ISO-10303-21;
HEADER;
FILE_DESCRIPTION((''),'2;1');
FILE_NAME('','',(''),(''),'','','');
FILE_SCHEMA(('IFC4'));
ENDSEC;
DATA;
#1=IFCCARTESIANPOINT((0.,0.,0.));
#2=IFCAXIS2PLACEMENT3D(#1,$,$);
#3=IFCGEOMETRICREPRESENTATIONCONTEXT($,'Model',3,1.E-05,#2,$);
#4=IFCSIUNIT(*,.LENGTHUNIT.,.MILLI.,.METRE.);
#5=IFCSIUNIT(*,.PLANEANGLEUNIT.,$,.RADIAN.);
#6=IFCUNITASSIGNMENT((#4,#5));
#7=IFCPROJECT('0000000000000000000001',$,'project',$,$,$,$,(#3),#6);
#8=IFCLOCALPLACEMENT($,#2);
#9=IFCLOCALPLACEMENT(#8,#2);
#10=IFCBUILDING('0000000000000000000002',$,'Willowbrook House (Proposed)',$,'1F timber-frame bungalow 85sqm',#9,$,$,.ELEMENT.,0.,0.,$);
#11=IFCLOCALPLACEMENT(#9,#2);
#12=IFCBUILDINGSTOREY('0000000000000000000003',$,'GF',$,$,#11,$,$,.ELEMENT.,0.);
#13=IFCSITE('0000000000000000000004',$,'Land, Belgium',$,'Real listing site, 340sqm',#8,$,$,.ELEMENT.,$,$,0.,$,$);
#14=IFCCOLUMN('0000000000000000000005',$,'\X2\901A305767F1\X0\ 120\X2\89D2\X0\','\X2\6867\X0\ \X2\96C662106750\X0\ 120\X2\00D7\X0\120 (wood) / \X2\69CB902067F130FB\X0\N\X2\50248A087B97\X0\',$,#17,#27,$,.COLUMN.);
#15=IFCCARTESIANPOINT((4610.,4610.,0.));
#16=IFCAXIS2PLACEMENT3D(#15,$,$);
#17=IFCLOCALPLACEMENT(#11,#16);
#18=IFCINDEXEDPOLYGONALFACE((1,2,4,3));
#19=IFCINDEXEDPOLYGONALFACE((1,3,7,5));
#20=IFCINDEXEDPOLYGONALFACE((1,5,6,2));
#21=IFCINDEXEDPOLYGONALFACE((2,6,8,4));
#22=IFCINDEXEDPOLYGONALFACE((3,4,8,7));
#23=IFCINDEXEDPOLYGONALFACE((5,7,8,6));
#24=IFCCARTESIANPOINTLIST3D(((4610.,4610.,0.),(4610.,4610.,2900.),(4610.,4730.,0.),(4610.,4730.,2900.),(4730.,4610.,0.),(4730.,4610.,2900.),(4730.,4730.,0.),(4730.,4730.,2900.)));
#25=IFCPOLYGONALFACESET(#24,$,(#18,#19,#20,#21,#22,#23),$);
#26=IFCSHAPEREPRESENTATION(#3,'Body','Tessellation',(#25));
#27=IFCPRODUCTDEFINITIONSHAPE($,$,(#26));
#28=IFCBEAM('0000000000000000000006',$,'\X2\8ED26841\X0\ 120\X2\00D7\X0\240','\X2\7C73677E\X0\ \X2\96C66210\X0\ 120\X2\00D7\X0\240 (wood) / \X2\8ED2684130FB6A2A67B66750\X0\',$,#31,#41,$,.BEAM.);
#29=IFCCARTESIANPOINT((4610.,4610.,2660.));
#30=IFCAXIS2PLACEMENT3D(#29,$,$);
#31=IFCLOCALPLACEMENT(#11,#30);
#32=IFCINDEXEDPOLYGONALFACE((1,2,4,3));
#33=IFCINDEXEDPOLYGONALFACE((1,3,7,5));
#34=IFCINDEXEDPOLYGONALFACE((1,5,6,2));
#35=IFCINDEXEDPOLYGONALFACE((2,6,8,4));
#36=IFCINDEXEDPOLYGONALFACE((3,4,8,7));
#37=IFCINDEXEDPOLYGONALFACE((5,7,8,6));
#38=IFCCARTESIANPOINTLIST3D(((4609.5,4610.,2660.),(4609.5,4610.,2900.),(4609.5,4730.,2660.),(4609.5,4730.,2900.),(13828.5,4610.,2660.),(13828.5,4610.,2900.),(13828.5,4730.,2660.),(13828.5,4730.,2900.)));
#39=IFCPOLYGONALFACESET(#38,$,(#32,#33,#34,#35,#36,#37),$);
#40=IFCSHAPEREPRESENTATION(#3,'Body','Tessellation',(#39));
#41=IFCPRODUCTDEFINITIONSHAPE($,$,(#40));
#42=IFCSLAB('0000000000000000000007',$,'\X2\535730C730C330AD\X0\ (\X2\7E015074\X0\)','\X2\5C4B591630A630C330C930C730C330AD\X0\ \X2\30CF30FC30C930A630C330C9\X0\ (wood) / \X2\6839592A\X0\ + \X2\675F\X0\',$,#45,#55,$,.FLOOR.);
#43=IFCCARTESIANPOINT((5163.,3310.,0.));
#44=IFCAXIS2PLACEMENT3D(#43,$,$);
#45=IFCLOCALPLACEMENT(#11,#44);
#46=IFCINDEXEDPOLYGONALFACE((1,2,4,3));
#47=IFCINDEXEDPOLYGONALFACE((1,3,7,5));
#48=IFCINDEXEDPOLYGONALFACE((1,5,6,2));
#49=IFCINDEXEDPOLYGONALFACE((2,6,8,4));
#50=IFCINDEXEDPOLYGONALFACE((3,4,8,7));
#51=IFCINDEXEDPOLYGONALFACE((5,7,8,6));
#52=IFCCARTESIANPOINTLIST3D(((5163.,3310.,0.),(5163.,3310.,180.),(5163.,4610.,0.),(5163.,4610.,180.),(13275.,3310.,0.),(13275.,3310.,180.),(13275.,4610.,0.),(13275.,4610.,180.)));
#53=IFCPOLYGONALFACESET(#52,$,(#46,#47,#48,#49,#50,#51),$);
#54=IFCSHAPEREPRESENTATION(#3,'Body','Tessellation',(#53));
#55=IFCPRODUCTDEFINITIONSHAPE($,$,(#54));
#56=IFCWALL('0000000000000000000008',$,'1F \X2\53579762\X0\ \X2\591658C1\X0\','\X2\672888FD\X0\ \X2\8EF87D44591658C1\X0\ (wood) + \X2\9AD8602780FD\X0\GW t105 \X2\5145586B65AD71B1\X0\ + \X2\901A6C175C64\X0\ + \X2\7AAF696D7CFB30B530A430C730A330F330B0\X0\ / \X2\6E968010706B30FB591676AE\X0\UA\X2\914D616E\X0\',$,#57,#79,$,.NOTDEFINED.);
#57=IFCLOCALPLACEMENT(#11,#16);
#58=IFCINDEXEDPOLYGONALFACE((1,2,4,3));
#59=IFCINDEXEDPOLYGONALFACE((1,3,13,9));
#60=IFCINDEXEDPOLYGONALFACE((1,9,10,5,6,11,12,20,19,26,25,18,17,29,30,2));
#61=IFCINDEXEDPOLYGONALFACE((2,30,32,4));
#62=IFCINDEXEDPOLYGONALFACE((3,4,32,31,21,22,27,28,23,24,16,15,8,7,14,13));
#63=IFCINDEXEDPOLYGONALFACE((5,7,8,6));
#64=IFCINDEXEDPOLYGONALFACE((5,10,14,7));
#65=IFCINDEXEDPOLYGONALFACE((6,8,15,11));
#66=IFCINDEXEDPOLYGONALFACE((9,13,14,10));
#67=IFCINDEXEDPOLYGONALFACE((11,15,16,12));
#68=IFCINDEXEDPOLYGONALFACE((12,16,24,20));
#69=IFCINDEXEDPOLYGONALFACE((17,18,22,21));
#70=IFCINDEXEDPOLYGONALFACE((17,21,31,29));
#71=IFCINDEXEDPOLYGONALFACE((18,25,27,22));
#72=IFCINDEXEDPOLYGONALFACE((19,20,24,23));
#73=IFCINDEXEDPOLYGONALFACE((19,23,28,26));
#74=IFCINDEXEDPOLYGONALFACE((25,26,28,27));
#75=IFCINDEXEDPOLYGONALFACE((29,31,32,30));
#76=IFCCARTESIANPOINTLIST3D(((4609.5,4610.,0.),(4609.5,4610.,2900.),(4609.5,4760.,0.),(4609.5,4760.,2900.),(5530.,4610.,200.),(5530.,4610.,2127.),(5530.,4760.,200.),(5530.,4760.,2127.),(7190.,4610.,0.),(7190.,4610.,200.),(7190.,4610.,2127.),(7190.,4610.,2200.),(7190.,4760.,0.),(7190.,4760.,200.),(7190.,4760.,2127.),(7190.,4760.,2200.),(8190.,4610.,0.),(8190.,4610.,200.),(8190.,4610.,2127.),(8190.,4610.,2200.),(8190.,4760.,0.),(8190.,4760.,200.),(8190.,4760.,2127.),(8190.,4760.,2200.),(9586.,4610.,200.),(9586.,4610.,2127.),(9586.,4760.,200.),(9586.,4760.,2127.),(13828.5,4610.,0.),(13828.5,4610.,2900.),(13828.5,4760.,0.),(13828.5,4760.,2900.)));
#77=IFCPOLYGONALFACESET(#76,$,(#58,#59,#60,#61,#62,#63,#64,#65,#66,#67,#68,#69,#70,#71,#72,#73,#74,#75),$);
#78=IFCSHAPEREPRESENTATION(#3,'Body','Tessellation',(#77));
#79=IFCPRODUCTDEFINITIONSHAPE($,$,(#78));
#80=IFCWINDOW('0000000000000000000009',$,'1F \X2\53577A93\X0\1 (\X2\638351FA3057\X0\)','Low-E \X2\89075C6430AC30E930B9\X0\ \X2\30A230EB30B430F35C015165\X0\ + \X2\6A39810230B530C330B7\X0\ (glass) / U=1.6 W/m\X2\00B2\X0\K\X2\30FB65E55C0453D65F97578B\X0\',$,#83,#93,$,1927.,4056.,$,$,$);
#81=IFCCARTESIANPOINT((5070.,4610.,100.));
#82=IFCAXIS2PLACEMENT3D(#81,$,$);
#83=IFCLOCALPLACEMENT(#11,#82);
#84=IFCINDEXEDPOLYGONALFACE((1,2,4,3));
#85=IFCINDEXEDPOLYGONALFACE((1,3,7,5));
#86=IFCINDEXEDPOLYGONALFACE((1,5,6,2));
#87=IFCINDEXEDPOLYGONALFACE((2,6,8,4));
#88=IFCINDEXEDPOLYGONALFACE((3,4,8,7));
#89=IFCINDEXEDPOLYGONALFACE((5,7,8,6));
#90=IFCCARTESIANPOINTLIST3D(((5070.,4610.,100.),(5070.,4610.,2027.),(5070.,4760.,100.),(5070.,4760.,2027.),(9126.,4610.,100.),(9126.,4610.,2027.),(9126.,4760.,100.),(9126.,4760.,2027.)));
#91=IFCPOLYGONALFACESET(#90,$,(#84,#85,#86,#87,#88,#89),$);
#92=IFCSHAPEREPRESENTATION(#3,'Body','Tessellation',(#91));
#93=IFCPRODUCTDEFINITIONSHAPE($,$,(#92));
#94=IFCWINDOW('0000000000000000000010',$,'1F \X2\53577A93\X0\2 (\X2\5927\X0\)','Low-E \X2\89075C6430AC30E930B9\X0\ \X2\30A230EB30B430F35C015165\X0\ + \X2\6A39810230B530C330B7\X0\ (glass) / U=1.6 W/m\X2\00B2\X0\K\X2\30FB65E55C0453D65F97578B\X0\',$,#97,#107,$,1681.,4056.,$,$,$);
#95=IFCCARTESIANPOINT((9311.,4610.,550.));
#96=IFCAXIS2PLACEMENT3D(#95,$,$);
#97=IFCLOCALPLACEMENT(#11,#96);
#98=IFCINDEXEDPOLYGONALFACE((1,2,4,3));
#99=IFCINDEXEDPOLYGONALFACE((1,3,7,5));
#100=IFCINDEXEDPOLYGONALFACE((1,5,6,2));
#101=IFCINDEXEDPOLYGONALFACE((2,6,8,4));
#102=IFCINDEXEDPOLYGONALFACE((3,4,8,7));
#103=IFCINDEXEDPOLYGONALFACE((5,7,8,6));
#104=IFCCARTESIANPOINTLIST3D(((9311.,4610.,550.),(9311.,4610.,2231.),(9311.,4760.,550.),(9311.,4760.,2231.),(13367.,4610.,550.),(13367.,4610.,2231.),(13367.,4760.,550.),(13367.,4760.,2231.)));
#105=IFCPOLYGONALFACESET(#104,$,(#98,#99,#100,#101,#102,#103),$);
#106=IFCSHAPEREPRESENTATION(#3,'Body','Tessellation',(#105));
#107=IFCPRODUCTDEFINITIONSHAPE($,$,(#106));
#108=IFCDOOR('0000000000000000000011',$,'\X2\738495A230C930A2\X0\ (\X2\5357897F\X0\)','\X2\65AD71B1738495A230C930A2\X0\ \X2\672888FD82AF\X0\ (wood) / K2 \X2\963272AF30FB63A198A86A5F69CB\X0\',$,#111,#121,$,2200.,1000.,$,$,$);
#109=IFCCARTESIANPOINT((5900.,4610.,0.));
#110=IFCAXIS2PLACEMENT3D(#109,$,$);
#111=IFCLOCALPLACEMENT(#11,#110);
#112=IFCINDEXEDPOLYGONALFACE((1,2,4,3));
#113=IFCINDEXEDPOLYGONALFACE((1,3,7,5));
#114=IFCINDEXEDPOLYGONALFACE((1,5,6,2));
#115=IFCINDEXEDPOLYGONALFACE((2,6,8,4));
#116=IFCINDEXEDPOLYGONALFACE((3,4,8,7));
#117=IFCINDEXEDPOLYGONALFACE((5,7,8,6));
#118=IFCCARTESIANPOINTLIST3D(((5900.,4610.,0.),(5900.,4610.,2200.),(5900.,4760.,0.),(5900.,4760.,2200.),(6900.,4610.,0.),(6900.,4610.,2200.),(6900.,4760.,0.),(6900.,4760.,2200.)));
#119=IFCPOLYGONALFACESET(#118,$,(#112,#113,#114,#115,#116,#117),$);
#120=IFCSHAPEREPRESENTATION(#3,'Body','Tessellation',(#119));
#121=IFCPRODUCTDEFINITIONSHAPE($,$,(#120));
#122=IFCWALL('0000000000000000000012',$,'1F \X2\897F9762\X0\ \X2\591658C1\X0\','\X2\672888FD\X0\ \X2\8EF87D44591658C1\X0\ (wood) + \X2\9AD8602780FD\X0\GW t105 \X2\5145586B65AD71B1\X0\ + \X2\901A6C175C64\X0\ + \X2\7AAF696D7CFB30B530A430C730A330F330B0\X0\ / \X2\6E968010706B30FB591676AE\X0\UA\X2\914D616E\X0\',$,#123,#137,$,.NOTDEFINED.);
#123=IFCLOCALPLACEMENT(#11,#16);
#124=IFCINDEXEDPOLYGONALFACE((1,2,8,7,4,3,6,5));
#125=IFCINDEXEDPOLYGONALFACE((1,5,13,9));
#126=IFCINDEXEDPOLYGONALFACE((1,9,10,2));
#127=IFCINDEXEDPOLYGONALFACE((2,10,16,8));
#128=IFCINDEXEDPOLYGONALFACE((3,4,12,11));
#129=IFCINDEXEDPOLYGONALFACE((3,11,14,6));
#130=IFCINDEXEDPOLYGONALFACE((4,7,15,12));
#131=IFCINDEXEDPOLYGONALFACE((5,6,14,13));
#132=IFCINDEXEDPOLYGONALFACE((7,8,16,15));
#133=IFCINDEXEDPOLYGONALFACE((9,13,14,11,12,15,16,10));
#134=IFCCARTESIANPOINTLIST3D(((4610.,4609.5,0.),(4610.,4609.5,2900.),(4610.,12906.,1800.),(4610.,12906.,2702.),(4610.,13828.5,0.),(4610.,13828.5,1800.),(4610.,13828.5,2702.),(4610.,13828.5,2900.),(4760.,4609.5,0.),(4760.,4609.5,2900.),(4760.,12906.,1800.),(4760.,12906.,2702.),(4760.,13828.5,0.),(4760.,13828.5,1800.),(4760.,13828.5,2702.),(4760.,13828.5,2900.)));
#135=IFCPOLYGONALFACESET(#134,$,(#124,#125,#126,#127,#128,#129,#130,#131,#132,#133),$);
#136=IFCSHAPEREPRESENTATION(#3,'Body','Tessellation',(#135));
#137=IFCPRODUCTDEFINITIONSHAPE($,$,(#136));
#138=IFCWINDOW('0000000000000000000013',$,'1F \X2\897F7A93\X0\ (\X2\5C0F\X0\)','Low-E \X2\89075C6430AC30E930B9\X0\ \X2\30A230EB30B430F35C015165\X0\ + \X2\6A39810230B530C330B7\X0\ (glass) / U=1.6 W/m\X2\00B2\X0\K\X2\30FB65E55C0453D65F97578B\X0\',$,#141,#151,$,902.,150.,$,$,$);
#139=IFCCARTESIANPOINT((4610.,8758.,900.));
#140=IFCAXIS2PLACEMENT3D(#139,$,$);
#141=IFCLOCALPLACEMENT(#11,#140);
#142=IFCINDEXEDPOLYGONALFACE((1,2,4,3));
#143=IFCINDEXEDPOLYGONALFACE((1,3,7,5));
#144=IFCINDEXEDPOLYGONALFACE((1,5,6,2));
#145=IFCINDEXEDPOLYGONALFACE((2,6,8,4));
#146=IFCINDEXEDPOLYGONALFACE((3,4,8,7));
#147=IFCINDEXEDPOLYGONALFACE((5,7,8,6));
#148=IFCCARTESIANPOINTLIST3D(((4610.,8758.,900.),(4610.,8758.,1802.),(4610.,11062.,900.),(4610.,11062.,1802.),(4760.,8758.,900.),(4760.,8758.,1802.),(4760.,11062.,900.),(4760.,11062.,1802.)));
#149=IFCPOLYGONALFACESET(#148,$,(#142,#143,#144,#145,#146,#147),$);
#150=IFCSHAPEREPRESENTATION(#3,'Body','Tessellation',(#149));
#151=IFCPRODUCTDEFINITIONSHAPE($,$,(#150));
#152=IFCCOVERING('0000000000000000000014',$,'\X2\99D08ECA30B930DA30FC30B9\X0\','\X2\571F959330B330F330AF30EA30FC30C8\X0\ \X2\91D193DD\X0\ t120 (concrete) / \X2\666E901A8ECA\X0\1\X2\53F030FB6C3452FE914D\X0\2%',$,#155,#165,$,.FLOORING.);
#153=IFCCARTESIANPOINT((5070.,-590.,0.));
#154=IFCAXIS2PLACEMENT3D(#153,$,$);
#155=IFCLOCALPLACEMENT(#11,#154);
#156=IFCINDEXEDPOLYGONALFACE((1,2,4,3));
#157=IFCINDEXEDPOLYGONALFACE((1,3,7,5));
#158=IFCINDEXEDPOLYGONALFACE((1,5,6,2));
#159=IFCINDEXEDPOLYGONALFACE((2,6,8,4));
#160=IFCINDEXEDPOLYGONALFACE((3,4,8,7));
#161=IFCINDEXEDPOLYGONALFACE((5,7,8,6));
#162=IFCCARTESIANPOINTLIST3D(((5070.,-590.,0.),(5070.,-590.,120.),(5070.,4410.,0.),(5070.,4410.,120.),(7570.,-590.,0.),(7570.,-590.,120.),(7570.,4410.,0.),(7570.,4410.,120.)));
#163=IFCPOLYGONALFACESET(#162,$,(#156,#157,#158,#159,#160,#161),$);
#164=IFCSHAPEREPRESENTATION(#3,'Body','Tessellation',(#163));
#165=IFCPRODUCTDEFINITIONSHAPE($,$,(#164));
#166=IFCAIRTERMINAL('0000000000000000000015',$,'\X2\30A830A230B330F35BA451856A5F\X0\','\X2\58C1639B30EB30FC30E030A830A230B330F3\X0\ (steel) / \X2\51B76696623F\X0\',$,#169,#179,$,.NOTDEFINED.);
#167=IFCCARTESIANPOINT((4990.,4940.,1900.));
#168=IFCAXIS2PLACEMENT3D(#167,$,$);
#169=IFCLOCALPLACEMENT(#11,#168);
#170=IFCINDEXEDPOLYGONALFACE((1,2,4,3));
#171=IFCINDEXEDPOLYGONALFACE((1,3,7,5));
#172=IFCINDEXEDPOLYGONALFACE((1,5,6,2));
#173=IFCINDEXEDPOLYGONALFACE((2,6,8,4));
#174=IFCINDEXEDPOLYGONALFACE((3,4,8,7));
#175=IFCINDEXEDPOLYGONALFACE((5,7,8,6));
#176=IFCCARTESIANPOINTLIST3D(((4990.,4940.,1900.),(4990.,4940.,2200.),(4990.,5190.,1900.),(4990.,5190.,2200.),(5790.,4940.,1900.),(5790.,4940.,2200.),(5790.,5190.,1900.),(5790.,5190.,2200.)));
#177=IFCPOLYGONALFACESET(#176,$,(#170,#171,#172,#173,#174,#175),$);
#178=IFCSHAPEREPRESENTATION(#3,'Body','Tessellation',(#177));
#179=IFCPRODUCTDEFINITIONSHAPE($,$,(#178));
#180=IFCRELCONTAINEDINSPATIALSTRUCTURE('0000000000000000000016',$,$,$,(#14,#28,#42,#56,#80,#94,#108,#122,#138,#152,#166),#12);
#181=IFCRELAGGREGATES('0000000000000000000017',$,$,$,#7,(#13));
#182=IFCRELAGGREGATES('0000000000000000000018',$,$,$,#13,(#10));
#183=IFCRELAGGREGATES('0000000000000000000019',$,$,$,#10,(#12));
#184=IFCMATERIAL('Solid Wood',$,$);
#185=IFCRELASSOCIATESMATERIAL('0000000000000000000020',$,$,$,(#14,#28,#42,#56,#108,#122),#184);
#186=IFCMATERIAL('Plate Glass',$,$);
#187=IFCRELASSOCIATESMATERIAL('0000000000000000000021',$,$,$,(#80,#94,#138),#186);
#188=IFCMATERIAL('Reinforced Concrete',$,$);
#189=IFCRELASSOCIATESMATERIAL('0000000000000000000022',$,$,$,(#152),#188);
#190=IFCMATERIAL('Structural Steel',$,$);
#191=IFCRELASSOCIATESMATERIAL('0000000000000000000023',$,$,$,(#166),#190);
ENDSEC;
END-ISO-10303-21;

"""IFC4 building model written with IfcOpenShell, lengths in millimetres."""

from ifc_helpers import new_model, si_unit, frame, frame_2d, origin, place, context, project, spatial, rectangle, extrude, material, element, fill, save


model = new_model("IFC4")

# Units and contexts
model_context = context("Model", 3, precision=1e-05, world=origin())
ifc_project = project(units=[si_unit("LENGTHUNIT", "METRE", prefix="MILLI"), si_unit("PLANEANGLEUNIT", "RADIAN")], contexts=[model_context])

# Site, building, storey
site_placement = place(None, origin())
site = spatial("IfcSite", under=ifc_project, at=site_placement, Name="Land, Belgium", ObjectType="Real listing site, 340sqm", CompositionType="ELEMENT", RefElevation=0.0)
building_placement = place(site_placement, origin())
building = spatial("IfcBuilding", under=site, at=building_placement, Name="Willowbrook House (Proposed)", ObjectType="1F timber-frame bungalow 85sqm", CompositionType="ELEMENT", ElevationOfRefHeight=0.0, ElevationOfTerrain=0.0)
storey_placement = place(building_placement, origin())
storey = spatial("IfcBuildingStorey", under=building, at=storey_placement, Name="GF", CompositionType="ELEMENT", Elevation=0.0)

# Column
ifc_material_1 = material(Name="Solid Wood")
column_1_placement = place(storey_placement, frame((4610.0, 4610.0, 0.0)))
element("IfcColumn", 1, at=column_1_placement, inside=storey, material=ifc_material_1, Name="通し柱 120角", Description="桧 集成材 120×120 (wood) / 構造柱・N値計算", PredefinedType="COLUMN", context=model_context, shape_type="SweptSolid", body=[
    extrude(rectangle(XDim=120.0, YDim=120.0, at=frame_2d((60.0, 60.0))), frame((4610.0, 4610.0, 0.0)), (0.0, 0.0, 1.0), 2900.0),
])

# Beam
beam_1_placement = place(storey_placement, frame((4610.0, 4610.0, 2660.0)))
element("IfcBeam", 2, at=beam_1_placement, inside=storey, material=ifc_material_1, Name="軒桁 120×240", Description="米松 集成 120×240 (wood) / 軒桁・横架材", PredefinedType="BEAM", context=model_context, shape_type="SweptSolid", body=[
    extrude(rectangle(XDim=9219.0, YDim=120.0, at=frame_2d((4609.0, 60.0))), frame((4610.0, 4610.0, 2660.0)), (0.0, 0.0, 1.0), 240.0),
])

# Slab
ifc_material_2 = material(Name="Reinforced Concrete")
slab_1_placement = place(storey_placement, frame((5163.0, 3310.0, 0.0)))
element("IfcSlab", 3, at=slab_1_placement, inside=storey, material=ifc_material_1, Name="南デッキ (縁側)", Description="屋外ウッドデッキ ハードウッド (wood) / 根太 + 束", PredefinedType="FLOOR", context=model_context, shape_type="SweptSolid", body=[
    extrude(rectangle(XDim=8112.0, YDim=1300.0, at=frame_2d((4056.0, 650.0))), frame((5163.0, 3310.0, 0.0)), (0.0, 0.0, 1.0), 180.0),
])

# Wall, openings, windows, door
wall_1_placement = place(storey_placement, frame((4610.0, 4610.0, 0.0)))
wall_1 = element("IfcWall", 4, at=wall_1_placement, inside=storey, material=ifc_material_1, Name="1F 南面 外壁", Description="木製 軸組外壁 (wood) + 高性能GW t105 充填断熱 + 通気層 + 窯業系サイディング / 準耐火・外皮UA配慮", PredefinedType="NOTDEFINED", context=model_context, shape_type="SweptSolid", body=[
    extrude(rectangle(XDim=9219.0, YDim=150.0, at=frame_2d((4609.0, 75.0))), frame((4610.0, 4610.0, 0.0)), (0.0, 0.0, 1.0), 2900.0),
])
opening_1_placement = place(storey_placement, frame((5070.0, 4610.0, 100.0)))
opening_1 = element("IfcOpeningElement", 5, at=opening_1_placement, cuts=wall_1, PredefinedType="NOTDEFINED", context=model_context, shape_type="SweptSolid", body=[
    extrude(rectangle(XDim=4056.0, YDim=150.0, at=frame_2d((2028.0, 75.0))), frame((5070.0, 4610.0, 100.0)), (0.0, 0.0, 1.0), 1927.0),
])
opening_2_placement = place(storey_placement, frame((9311.0, 4610.0, 550.0)))
opening_2 = element("IfcOpeningElement", 6, at=opening_2_placement, cuts=wall_1, PredefinedType="NOTDEFINED", context=model_context, shape_type="SweptSolid", body=[
    extrude(rectangle(XDim=4056.0, YDim=150.0, at=frame_2d((2028.0, 75.0))), frame((9311.0, 4610.0, 550.0)), (0.0, 0.0, 1.0), 1681.0),
])
opening_3_placement = place(storey_placement, frame((5900.0, 4610.0, 0.0)))
opening_3 = element("IfcOpeningElement", 7, at=opening_3_placement, cuts=wall_1, PredefinedType="NOTDEFINED", context=model_context, shape_type="SweptSolid", body=[
    extrude(rectangle(XDim=1000.0, YDim=150.0, at=frame_2d((500.0, 75.0))), frame((5900.0, 4610.0, 0.0)), (0.0, 0.0, 1.0), 2200.0),
])
ifc_material_3 = material(Name="Plate Glass")
window_1_placement = place(storey_placement, frame((5070.0, 4610.0, 100.0)))
window_1 = element("IfcWindow", 8, at=window_1_placement, inside=storey, material=ifc_material_3, Name="1F 南窓1 (掃出し)", Description="Low-E 複層ガラス アルゴン封入 + 樹脂サッシ (glass) / U=1.6 W/m²K・日射取得型", OverallHeight=1927.0, OverallWidth=4056.0, context=model_context, shape_type="SweptSolid", body=[
    extrude(rectangle(XDim=4056.0, YDim=150.0, at=frame_2d((2028.0, 75.0))), frame((5070.0, 4610.0, 100.0)), (0.0, 0.0, 1.0), 1927.0),
])
fill(opening_1, window_1)
window_2_placement = place(storey_placement, frame((9311.0, 4610.0, 550.0)))
window_2 = element("IfcWindow", 9, at=window_2_placement, inside=storey, material=ifc_material_3, Name="1F 南窓2 (大)", Description="Low-E 複層ガラス アルゴン封入 + 樹脂サッシ (glass) / U=1.6 W/m²K・日射取得型", OverallHeight=1681.0, OverallWidth=4056.0, context=model_context, shape_type="SweptSolid", body=[
    extrude(rectangle(XDim=4056.0, YDim=150.0, at=frame_2d((2028.0, 75.0))), frame((9311.0, 4610.0, 550.0)), (0.0, 0.0, 1.0), 1681.0),
])
fill(opening_2, window_2)
door_placement = place(storey_placement, frame((5900.0, 4610.0, 0.0)))
door = element("IfcDoor", 10, at=door_placement, inside=storey, material=ifc_material_1, Name="玄関ドア (南西)", Description="断熱玄関ドア 木製芯 (wood) / K2 防犯・採風機構", OverallHeight=2200.0, OverallWidth=1000.0, context=model_context, shape_type="SweptSolid", body=[
    extrude(rectangle(XDim=1000.0, YDim=150.0, at=frame_2d((500.0, 75.0))), frame((5900.0, 4610.0, 0.0)), (0.0, 0.0, 1.0), 2200.0),
])
fill(opening_3, door)

# Wall, opening, window
wall_2_placement = place(storey_placement, frame((4610.0, 4610.0, 0.0)))
wall_2 = element("IfcWall", 11, at=wall_2_placement, inside=storey, material=ifc_material_1, Name="1F 西面 外壁", Description="木製 軸組外壁 (wood) + 高性能GW t105 充填断熱 + 通気層 + 窯業系サイディング / 準耐火・外皮UA配慮", PredefinedType="NOTDEFINED", context=model_context, shape_type="SweptSolid", body=[
    extrude(rectangle(XDim=150.0, YDim=9219.0, at=frame_2d((75.0, 4609.0))), frame((4610.0, 4610.0, 0.0)), (0.0, 0.0, 1.0), 2900.0),
])
opening_4_placement = place(storey_placement, frame((4610.0, 8758.0, 900.0)))
opening_4 = element("IfcOpeningElement", 12, at=opening_4_placement, cuts=wall_2, PredefinedType="NOTDEFINED", context=model_context, shape_type="SweptSolid", body=[
    extrude(rectangle(XDim=150.0, YDim=2304.0, at=frame_2d((75.0, 1152.0))), frame((4610.0, 8758.0, 900.0)), (0.0, 0.0, 1.0), 902.0),
])
window_3_placement = place(storey_placement, frame((4610.0, 8758.0, 900.0)))
window_3 = element("IfcWindow", 13, at=window_3_placement, inside=storey, material=ifc_material_3, Name="1F 西窓 (小)", Description="Low-E 複層ガラス アルゴン封入 + 樹脂サッシ (glass) / U=1.6 W/m²K・日射取得型", OverallHeight=902.0, OverallWidth=150.0, context=model_context, shape_type="SweptSolid", body=[
    extrude(rectangle(XDim=150.0, YDim=2304.0, at=frame_2d((75.0, 1152.0))), frame((4610.0, 8758.0, 900.0)), (0.0, 0.0, 1.0), 902.0),
])
fill(opening_4, window_3)

# Shared definitions
ifc_material_4 = material(Name="Structural Steel")

# Covering
covering_1_placement = place(storey_placement, frame((5070.0, -590.0, 0.0)))
element("IfcCovering", 14, at=covering_1_placement, inside=storey, material=ifc_material_2, Name="駐車スペース", Description="土間コンクリート 金鏝 t120 (concrete) / 普通車1台・水勾配2%", PredefinedType="FLOORING", context=model_context, shape_type="SweptSolid", body=[
    extrude(rectangle(XDim=2500.0, YDim=5000.0, at=frame_2d((1250.0, 2500.0))), frame((5070.0, -590.0, 0.0)), (0.0, 0.0, 1.0), 120.0),
])

# Air terminal
air_terminal_placement = place(storey_placement, frame((4990.0, 4940.0, 1900.0)))
element("IfcAirTerminal", 15, at=air_terminal_placement, inside=storey, material=ifc_material_4, Name="エアコン室内機", Description="壁掛ルームエアコン (steel) / 冷暖房", PredefinedType="NOTDEFINED", context=model_context, shape_type="SweptSolid", body=[
    extrude(rectangle(XDim=800.0, YDim=250.0, at=frame_2d((400.0, 125.0))), frame((4990.0, 4940.0, 1900.0)), (0.0, 0.0, 1.0), 300.0),
])

save(model, "model.ifc")
